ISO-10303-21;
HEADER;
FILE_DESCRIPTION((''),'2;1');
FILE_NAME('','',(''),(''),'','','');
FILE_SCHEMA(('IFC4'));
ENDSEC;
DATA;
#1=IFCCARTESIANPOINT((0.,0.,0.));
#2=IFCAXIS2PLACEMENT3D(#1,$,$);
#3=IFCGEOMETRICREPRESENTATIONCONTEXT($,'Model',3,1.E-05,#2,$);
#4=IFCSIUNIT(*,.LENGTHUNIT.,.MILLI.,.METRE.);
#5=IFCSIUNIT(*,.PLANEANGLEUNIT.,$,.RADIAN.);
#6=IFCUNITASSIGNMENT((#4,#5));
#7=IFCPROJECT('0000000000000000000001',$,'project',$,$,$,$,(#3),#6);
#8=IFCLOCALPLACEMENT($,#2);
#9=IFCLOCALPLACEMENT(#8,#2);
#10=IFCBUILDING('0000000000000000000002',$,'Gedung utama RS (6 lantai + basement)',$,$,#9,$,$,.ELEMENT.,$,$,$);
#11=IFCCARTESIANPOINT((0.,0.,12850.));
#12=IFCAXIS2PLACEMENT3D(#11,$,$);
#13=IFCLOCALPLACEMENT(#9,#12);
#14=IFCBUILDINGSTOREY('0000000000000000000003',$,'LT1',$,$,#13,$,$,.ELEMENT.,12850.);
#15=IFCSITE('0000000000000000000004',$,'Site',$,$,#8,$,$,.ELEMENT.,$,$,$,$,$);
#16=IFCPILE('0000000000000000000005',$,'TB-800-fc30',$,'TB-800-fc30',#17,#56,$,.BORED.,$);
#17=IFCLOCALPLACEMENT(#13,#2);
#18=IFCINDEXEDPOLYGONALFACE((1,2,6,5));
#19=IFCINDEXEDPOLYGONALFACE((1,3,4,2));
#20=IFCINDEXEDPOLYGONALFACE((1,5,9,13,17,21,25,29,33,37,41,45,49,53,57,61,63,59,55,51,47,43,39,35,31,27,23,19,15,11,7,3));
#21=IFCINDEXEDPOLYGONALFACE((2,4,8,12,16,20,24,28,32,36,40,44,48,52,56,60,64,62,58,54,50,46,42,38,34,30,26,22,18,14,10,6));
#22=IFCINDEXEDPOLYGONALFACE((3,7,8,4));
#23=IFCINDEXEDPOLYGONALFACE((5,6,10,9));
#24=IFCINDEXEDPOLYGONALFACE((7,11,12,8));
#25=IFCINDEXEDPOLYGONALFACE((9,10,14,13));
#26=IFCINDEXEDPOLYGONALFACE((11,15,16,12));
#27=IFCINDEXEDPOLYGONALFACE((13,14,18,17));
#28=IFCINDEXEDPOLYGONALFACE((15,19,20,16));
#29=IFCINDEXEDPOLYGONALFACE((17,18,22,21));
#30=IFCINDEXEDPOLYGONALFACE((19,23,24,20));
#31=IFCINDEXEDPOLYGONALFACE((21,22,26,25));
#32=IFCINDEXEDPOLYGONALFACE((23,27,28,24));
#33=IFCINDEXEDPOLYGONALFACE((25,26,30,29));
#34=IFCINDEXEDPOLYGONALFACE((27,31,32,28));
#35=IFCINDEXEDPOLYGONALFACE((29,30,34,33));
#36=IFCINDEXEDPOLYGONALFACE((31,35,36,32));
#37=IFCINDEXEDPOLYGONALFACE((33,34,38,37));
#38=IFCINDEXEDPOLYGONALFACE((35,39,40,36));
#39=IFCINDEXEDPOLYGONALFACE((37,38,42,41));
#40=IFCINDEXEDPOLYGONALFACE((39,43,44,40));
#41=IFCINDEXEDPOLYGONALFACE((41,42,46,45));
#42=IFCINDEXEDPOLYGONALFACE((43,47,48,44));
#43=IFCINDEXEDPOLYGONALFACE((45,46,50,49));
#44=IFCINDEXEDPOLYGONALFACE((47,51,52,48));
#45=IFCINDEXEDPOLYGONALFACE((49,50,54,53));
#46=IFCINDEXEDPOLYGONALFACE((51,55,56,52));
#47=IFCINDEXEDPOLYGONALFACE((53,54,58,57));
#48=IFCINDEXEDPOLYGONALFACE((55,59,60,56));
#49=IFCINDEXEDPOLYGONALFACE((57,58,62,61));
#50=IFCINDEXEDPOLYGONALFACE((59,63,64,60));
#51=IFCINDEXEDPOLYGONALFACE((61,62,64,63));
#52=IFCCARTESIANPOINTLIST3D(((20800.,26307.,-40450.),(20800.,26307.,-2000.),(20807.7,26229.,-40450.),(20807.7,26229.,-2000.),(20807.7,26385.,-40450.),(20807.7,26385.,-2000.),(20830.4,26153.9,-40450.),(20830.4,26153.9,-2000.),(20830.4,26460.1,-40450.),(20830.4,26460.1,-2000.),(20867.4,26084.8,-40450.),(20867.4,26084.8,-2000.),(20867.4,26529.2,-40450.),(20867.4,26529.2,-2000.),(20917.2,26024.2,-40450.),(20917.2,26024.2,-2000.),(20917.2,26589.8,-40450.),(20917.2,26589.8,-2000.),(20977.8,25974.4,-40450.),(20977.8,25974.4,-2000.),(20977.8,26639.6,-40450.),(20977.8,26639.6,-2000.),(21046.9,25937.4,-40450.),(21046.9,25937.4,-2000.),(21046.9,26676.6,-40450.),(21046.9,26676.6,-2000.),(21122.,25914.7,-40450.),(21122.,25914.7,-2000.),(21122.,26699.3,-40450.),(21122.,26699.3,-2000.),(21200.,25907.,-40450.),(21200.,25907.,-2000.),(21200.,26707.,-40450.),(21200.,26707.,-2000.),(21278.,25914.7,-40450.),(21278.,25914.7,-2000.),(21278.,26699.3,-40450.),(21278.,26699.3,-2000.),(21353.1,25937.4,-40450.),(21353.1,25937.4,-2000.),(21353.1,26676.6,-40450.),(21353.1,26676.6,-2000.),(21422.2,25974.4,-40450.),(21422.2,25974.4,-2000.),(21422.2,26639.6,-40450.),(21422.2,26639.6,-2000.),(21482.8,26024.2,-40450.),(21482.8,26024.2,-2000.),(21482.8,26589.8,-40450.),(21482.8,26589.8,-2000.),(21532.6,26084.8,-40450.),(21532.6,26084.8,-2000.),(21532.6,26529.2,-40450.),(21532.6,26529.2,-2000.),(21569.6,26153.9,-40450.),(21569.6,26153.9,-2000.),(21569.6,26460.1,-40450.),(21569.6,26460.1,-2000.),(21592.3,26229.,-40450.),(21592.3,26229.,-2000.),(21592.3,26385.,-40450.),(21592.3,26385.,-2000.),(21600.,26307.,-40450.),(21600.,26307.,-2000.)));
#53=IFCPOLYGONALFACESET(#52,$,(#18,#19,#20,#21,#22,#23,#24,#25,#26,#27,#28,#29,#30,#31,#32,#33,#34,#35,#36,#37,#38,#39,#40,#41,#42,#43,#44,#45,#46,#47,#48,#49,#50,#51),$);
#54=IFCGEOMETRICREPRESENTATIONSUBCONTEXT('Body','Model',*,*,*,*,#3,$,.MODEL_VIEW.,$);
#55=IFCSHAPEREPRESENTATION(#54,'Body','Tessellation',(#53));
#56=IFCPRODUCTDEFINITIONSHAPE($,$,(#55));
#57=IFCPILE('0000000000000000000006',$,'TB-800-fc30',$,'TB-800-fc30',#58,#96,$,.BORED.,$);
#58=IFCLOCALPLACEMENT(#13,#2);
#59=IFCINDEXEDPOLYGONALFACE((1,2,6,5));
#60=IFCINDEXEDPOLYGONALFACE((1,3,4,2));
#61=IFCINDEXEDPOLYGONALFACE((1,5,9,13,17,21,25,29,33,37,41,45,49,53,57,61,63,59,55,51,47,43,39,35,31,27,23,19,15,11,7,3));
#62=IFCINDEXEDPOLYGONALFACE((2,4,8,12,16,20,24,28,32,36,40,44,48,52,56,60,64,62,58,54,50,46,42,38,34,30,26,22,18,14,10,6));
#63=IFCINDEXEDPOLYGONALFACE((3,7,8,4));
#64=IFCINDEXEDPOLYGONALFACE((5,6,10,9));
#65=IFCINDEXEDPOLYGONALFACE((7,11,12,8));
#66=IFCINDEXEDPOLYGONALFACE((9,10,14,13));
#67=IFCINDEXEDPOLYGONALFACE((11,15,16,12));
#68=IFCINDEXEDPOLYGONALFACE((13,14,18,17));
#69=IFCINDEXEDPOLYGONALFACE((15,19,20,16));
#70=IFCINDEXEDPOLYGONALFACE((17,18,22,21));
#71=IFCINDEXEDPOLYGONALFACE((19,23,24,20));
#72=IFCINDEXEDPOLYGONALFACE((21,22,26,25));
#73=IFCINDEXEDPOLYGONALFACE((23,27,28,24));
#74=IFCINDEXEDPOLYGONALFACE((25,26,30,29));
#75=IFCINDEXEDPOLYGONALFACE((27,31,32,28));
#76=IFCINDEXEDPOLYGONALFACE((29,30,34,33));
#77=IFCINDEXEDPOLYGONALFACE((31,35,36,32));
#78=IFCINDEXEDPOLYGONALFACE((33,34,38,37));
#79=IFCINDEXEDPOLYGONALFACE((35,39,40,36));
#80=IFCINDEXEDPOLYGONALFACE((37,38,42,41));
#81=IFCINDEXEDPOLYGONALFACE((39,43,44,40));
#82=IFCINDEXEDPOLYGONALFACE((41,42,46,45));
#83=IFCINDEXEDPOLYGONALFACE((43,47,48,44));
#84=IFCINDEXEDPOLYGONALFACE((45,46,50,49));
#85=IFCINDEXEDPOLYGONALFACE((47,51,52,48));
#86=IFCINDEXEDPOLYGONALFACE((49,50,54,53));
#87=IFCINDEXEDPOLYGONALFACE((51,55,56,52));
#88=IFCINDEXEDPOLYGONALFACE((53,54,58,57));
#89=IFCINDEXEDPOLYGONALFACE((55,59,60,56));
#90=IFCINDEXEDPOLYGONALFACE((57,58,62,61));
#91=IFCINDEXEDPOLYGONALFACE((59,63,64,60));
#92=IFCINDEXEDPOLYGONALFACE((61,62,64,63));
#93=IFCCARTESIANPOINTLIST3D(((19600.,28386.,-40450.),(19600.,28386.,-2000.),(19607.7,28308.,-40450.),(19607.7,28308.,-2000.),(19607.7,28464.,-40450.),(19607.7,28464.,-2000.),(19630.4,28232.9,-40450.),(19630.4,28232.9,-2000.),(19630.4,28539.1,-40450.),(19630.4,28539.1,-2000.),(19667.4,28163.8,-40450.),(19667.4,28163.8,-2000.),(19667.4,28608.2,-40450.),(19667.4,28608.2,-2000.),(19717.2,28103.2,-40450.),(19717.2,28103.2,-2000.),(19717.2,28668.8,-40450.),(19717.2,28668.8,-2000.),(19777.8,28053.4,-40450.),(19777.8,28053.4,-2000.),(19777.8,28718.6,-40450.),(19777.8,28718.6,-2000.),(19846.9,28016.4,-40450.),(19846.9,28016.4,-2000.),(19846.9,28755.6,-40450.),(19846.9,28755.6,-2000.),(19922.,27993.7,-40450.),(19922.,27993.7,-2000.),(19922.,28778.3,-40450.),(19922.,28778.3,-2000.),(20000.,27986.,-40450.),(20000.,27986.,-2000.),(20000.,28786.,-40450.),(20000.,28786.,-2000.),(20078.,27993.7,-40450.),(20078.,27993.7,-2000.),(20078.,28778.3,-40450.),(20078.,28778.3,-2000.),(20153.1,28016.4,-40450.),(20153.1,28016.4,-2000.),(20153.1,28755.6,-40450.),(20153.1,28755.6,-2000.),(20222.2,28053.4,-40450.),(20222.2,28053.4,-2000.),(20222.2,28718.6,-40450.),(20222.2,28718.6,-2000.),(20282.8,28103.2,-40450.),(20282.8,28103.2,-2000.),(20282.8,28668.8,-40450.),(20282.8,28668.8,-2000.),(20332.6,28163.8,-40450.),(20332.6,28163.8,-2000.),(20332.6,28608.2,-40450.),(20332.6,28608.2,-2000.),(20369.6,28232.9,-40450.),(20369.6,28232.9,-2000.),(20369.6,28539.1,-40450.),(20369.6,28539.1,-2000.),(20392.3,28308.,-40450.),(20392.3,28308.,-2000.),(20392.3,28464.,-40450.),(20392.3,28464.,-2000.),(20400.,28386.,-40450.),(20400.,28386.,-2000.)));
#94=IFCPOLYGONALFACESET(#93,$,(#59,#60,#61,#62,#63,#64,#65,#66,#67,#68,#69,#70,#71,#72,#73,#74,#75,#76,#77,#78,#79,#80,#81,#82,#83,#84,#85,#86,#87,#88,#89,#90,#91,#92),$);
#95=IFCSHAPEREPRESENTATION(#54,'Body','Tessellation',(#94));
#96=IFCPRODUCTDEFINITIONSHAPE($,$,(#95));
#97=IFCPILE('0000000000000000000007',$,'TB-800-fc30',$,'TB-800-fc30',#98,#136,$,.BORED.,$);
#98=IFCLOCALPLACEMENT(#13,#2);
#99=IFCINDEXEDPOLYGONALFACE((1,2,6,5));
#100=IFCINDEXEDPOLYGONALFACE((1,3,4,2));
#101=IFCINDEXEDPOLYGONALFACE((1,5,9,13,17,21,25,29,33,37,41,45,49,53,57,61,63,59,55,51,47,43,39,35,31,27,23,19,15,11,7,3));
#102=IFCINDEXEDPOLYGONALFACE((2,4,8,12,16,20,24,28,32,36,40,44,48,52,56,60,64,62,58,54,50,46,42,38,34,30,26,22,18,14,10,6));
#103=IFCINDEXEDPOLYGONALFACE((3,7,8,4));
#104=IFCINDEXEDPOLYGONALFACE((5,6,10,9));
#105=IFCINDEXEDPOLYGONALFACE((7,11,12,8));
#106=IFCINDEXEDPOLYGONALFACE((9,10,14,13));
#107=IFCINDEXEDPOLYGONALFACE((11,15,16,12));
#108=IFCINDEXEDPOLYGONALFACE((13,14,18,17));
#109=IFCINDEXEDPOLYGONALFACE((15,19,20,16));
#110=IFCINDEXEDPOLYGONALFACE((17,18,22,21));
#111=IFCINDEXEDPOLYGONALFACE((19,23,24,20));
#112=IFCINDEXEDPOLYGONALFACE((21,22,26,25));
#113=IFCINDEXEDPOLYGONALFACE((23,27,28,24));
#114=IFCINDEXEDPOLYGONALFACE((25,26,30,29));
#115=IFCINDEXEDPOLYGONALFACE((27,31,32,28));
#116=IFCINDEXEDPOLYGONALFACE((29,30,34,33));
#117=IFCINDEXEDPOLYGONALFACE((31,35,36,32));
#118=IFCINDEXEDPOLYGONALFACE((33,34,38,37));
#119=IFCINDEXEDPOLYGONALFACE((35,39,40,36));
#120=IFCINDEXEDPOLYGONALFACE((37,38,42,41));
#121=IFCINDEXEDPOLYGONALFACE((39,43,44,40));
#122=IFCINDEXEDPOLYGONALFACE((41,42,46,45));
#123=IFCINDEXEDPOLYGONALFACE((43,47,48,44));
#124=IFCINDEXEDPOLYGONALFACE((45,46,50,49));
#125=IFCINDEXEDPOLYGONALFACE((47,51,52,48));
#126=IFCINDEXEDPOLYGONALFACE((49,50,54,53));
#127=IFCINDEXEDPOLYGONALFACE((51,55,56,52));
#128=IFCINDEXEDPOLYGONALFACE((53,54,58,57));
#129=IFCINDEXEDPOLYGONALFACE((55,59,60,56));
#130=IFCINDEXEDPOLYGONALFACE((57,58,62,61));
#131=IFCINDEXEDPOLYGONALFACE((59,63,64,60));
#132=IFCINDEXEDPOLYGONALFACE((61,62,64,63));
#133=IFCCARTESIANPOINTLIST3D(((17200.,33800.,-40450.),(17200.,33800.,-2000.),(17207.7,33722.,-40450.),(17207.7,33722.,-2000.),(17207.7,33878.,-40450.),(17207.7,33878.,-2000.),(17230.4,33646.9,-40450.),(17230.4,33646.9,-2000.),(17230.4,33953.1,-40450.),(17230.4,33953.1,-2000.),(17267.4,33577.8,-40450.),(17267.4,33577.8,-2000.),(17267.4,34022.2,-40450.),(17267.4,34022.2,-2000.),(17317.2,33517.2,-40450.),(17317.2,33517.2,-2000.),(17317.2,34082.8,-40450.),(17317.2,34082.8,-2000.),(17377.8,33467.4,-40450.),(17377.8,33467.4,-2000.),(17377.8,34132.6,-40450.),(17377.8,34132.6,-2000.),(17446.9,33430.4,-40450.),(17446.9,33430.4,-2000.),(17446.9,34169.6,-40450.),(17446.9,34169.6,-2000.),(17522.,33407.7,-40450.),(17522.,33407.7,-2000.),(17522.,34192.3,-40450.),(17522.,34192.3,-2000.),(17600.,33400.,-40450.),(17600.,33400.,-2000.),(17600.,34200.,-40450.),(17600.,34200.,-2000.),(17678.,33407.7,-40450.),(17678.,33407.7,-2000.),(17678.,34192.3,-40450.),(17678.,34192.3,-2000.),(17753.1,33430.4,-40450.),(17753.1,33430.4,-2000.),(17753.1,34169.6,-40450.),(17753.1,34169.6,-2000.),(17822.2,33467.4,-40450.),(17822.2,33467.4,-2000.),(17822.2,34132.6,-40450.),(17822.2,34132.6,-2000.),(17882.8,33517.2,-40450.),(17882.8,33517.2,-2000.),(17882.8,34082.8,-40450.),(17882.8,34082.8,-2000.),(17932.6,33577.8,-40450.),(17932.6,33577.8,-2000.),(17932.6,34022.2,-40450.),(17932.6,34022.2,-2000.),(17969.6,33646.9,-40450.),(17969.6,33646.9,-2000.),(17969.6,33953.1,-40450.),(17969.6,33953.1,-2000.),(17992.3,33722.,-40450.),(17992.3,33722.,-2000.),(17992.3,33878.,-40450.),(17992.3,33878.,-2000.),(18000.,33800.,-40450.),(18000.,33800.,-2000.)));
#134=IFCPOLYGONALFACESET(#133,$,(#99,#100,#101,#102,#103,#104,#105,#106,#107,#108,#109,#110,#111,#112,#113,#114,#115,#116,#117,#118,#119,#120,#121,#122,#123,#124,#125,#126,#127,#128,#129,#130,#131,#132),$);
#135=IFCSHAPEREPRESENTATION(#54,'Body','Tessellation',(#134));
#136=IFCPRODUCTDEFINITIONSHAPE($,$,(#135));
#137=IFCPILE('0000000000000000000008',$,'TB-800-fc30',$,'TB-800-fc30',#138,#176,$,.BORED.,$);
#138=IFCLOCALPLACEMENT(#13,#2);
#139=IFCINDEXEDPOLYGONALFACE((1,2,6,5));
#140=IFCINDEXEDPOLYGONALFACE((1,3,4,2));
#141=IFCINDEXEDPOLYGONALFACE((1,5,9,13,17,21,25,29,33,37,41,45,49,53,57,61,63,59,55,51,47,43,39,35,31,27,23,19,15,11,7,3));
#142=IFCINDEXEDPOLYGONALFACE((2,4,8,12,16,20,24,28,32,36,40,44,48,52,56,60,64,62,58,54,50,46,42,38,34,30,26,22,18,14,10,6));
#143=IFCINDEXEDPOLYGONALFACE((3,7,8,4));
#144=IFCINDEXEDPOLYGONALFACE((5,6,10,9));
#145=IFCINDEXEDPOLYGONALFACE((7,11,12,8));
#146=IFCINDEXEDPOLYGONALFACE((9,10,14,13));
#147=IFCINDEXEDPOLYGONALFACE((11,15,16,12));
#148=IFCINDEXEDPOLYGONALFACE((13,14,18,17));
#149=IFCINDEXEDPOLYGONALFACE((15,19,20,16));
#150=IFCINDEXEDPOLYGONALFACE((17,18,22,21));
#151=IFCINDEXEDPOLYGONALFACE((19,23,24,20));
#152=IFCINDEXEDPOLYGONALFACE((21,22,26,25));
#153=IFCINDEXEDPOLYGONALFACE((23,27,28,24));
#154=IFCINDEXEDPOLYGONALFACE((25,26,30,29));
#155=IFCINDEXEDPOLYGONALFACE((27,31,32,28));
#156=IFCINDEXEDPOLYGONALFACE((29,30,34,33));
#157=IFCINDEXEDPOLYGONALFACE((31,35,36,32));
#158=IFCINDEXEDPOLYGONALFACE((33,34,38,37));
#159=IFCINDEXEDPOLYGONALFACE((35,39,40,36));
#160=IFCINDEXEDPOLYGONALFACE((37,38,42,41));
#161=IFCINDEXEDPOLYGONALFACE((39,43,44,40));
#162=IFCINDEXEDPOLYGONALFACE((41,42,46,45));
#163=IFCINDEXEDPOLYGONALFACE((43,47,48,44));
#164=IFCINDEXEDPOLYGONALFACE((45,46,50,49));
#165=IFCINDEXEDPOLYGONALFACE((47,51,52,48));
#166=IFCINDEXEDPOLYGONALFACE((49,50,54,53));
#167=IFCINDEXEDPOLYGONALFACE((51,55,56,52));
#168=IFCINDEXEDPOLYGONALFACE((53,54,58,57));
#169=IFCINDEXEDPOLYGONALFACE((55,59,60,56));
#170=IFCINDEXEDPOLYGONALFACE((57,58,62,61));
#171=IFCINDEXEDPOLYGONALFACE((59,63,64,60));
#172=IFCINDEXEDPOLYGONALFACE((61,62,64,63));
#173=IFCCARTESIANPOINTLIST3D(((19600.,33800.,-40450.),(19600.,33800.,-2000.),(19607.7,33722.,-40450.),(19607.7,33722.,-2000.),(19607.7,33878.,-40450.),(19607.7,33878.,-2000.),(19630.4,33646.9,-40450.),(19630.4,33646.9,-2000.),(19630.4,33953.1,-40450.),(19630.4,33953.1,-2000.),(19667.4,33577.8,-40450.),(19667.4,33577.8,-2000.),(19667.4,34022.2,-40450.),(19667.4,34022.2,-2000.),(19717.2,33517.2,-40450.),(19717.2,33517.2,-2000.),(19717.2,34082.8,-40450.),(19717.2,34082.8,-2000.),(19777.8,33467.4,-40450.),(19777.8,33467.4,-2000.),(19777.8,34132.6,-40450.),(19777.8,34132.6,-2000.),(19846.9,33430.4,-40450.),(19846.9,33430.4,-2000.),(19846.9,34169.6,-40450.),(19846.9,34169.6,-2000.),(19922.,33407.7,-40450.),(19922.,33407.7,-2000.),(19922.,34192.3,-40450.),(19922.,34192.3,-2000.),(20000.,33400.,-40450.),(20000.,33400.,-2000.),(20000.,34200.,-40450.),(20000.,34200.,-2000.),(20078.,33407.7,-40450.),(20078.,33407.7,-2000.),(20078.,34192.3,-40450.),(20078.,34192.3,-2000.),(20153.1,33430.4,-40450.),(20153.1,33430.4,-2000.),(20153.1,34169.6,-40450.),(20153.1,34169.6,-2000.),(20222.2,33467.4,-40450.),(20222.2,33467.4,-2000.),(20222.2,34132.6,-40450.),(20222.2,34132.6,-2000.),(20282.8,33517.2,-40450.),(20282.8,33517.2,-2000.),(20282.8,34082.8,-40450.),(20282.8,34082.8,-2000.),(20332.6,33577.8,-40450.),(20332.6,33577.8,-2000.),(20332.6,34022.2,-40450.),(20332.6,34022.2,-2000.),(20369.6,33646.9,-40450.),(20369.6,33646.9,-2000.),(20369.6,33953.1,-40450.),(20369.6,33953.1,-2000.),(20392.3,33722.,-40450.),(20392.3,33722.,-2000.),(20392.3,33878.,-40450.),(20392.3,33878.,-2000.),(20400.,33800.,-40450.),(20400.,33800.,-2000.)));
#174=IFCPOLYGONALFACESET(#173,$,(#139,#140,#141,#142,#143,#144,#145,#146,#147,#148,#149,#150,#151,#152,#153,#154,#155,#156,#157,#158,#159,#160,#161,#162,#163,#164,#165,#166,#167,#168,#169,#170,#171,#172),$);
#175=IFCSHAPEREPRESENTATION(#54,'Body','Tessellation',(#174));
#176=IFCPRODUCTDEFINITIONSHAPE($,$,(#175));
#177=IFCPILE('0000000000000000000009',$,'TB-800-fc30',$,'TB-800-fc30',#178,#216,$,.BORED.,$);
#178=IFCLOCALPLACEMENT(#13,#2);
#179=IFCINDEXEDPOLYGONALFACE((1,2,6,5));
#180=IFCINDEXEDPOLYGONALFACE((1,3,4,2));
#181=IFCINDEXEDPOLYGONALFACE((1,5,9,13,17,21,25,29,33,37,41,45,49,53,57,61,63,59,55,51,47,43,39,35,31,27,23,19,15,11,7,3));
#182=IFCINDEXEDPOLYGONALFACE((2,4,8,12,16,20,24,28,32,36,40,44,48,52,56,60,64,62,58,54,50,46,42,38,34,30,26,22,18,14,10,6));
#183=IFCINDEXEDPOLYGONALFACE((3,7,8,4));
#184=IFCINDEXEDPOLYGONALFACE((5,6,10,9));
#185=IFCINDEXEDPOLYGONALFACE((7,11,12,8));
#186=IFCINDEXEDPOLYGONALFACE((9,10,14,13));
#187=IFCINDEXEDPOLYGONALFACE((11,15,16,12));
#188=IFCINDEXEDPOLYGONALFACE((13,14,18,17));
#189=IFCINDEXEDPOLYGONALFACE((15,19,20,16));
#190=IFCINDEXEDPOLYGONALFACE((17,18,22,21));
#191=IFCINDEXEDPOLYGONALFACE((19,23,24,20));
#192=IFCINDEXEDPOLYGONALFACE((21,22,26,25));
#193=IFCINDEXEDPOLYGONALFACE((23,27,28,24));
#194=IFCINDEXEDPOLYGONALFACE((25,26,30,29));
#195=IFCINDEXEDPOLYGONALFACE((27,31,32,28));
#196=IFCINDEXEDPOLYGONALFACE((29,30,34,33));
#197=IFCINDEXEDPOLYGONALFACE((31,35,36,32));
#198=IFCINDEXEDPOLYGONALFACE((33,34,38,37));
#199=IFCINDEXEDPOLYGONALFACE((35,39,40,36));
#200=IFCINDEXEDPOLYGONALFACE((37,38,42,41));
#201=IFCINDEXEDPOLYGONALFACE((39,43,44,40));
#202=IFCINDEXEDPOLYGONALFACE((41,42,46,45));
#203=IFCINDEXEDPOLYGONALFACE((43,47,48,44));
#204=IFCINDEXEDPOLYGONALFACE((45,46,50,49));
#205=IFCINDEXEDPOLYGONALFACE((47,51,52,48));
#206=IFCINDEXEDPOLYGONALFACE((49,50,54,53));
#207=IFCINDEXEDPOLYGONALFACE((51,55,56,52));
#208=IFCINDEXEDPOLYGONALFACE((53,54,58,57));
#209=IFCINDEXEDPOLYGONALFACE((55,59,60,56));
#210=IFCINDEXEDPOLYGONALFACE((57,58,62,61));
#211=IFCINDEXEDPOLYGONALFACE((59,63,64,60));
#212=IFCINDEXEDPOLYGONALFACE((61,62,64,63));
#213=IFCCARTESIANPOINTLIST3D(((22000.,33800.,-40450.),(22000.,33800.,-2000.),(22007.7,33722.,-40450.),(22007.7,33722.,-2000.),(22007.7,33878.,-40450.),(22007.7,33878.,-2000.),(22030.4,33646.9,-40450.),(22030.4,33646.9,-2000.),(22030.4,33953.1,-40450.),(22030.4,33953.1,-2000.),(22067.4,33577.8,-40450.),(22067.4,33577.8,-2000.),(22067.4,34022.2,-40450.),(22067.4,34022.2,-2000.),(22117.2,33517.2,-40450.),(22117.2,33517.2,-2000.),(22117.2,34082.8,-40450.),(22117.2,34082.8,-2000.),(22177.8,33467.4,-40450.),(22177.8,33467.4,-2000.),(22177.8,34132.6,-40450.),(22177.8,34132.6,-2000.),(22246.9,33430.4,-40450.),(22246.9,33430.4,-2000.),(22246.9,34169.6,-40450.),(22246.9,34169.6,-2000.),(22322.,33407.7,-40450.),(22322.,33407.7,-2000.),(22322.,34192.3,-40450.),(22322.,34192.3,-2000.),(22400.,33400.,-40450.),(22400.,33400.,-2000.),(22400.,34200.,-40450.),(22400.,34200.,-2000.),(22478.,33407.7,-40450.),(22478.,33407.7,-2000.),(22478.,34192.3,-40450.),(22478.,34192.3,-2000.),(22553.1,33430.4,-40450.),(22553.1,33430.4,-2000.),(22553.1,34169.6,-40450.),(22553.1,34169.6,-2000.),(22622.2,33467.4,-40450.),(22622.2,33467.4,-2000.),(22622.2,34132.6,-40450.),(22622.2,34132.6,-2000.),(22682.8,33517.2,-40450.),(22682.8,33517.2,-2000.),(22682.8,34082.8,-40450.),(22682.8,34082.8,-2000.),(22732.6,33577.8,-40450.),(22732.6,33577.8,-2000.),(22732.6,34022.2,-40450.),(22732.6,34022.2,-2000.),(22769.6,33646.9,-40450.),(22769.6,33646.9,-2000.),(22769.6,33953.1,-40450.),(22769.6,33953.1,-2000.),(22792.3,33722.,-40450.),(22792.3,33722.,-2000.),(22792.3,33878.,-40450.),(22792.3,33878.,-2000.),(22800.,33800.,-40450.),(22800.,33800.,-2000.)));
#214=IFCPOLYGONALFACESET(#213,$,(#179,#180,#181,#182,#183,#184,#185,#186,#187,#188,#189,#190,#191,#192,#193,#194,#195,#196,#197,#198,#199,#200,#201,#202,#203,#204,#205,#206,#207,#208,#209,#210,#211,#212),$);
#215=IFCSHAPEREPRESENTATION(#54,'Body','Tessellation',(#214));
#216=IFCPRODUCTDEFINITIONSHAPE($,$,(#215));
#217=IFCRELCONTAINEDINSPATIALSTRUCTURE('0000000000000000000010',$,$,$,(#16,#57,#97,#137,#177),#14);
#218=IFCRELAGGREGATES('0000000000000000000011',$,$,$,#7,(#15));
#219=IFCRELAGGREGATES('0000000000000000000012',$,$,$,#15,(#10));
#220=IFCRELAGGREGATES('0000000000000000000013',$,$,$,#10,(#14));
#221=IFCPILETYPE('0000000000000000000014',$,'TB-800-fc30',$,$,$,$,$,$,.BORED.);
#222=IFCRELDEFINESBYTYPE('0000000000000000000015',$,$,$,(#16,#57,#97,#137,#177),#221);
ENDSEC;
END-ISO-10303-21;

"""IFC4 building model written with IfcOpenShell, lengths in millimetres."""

from ifc_helpers import new_model, si_unit, frame, origin, origin_2d, place, context, subcontext, project, spatial, circle, extrude, material_profile, profile_set, profile_usage, type_object, element, save


model = new_model("IFC4")

# Units and contexts
model_context = context("Model", 3, precision=1e-05, world=origin())
body_context = subcontext(model_context, "Body", "Model", "MODEL_VIEW")
ifc_project = project(units=[si_unit("LENGTHUNIT", "METRE", prefix="MILLI"), si_unit("PLANEANGLEUNIT", "RADIAN")], contexts=[model_context])

# Site, building, storey
site_placement = place(None, origin())
site = spatial("IfcSite", under=ifc_project, at=site_placement, Name="Site", CompositionType="ELEMENT")
building_placement = place(site_placement, origin())
building = spatial("IfcBuilding", under=site, at=building_placement, Name="Gedung utama RS (6 lantai + basement)", CompositionType="ELEMENT")
storey_placement = place(building_placement, frame((0.0, 0.0, 12850.0)))
storey = spatial("IfcBuildingStorey", under=building, at=storey_placement, Name="LT1", CompositionType="ELEMENT", Elevation=12850.0)

# Piles
ifc_material_profile_1 = material_profile(None, circle(Radius=400.0, at=origin_2d()), Name="TB-800-fc30")
ifc_profile_set_1 = profile_set([ifc_material_profile_1], Name="TB-800-fc30")
ifc_profile_usage_1 = profile_usage(ifc_profile_set_1, cardinal=5)
pile_type = type_object("IfcPileType", Name="TB-800-fc30", PredefinedType="BORED", material=ifc_profile_set_1)
for number, where, z_axis, x_axis, name in (
    (1, (21200.0, 26307.0, -40450.0), (0.0, 0.0, 1.0), (1.0, 0.0, 0.0), "TB-800-fc30"),
    (2, (20000.0, 28386.0, -40450.0), (0.0, 0.0, 1.0), (1.0, 0.0, 0.0), "TB-800-fc30"),
    (3, (17600.0, 33800.0, -40450.0), (0.0, 0.0, 1.0), (1.0, 0.0, 0.0), "TB-800-fc30"),
    (4, (20000.0, 33800.0, -40450.0), (0.0, 0.0, 1.0), (1.0, 0.0, 0.0), "TB-800-fc30"),
    (5, (22400.0, 33800.0, -40450.0), (0.0, 0.0, 1.0), (1.0, 0.0, 0.0), "TB-800-fc30"),
):
    element("IfcPile", number, at=place(storey_placement, frame(where, z_axis=z_axis, x_axis=x_axis)), inside=storey, type_object=pile_type, material=ifc_profile_usage_1, Name=name, ObjectType="TB-800-fc30", PredefinedType="BORED", context=body_context, shape_type="SweptSolid", body=[
        extrude(circle(Radius=400.0, at=origin_2d()), origin(), (0.0, 0.0, 1.0), 38450.0),
    ])

save(model, "model.ifc")
